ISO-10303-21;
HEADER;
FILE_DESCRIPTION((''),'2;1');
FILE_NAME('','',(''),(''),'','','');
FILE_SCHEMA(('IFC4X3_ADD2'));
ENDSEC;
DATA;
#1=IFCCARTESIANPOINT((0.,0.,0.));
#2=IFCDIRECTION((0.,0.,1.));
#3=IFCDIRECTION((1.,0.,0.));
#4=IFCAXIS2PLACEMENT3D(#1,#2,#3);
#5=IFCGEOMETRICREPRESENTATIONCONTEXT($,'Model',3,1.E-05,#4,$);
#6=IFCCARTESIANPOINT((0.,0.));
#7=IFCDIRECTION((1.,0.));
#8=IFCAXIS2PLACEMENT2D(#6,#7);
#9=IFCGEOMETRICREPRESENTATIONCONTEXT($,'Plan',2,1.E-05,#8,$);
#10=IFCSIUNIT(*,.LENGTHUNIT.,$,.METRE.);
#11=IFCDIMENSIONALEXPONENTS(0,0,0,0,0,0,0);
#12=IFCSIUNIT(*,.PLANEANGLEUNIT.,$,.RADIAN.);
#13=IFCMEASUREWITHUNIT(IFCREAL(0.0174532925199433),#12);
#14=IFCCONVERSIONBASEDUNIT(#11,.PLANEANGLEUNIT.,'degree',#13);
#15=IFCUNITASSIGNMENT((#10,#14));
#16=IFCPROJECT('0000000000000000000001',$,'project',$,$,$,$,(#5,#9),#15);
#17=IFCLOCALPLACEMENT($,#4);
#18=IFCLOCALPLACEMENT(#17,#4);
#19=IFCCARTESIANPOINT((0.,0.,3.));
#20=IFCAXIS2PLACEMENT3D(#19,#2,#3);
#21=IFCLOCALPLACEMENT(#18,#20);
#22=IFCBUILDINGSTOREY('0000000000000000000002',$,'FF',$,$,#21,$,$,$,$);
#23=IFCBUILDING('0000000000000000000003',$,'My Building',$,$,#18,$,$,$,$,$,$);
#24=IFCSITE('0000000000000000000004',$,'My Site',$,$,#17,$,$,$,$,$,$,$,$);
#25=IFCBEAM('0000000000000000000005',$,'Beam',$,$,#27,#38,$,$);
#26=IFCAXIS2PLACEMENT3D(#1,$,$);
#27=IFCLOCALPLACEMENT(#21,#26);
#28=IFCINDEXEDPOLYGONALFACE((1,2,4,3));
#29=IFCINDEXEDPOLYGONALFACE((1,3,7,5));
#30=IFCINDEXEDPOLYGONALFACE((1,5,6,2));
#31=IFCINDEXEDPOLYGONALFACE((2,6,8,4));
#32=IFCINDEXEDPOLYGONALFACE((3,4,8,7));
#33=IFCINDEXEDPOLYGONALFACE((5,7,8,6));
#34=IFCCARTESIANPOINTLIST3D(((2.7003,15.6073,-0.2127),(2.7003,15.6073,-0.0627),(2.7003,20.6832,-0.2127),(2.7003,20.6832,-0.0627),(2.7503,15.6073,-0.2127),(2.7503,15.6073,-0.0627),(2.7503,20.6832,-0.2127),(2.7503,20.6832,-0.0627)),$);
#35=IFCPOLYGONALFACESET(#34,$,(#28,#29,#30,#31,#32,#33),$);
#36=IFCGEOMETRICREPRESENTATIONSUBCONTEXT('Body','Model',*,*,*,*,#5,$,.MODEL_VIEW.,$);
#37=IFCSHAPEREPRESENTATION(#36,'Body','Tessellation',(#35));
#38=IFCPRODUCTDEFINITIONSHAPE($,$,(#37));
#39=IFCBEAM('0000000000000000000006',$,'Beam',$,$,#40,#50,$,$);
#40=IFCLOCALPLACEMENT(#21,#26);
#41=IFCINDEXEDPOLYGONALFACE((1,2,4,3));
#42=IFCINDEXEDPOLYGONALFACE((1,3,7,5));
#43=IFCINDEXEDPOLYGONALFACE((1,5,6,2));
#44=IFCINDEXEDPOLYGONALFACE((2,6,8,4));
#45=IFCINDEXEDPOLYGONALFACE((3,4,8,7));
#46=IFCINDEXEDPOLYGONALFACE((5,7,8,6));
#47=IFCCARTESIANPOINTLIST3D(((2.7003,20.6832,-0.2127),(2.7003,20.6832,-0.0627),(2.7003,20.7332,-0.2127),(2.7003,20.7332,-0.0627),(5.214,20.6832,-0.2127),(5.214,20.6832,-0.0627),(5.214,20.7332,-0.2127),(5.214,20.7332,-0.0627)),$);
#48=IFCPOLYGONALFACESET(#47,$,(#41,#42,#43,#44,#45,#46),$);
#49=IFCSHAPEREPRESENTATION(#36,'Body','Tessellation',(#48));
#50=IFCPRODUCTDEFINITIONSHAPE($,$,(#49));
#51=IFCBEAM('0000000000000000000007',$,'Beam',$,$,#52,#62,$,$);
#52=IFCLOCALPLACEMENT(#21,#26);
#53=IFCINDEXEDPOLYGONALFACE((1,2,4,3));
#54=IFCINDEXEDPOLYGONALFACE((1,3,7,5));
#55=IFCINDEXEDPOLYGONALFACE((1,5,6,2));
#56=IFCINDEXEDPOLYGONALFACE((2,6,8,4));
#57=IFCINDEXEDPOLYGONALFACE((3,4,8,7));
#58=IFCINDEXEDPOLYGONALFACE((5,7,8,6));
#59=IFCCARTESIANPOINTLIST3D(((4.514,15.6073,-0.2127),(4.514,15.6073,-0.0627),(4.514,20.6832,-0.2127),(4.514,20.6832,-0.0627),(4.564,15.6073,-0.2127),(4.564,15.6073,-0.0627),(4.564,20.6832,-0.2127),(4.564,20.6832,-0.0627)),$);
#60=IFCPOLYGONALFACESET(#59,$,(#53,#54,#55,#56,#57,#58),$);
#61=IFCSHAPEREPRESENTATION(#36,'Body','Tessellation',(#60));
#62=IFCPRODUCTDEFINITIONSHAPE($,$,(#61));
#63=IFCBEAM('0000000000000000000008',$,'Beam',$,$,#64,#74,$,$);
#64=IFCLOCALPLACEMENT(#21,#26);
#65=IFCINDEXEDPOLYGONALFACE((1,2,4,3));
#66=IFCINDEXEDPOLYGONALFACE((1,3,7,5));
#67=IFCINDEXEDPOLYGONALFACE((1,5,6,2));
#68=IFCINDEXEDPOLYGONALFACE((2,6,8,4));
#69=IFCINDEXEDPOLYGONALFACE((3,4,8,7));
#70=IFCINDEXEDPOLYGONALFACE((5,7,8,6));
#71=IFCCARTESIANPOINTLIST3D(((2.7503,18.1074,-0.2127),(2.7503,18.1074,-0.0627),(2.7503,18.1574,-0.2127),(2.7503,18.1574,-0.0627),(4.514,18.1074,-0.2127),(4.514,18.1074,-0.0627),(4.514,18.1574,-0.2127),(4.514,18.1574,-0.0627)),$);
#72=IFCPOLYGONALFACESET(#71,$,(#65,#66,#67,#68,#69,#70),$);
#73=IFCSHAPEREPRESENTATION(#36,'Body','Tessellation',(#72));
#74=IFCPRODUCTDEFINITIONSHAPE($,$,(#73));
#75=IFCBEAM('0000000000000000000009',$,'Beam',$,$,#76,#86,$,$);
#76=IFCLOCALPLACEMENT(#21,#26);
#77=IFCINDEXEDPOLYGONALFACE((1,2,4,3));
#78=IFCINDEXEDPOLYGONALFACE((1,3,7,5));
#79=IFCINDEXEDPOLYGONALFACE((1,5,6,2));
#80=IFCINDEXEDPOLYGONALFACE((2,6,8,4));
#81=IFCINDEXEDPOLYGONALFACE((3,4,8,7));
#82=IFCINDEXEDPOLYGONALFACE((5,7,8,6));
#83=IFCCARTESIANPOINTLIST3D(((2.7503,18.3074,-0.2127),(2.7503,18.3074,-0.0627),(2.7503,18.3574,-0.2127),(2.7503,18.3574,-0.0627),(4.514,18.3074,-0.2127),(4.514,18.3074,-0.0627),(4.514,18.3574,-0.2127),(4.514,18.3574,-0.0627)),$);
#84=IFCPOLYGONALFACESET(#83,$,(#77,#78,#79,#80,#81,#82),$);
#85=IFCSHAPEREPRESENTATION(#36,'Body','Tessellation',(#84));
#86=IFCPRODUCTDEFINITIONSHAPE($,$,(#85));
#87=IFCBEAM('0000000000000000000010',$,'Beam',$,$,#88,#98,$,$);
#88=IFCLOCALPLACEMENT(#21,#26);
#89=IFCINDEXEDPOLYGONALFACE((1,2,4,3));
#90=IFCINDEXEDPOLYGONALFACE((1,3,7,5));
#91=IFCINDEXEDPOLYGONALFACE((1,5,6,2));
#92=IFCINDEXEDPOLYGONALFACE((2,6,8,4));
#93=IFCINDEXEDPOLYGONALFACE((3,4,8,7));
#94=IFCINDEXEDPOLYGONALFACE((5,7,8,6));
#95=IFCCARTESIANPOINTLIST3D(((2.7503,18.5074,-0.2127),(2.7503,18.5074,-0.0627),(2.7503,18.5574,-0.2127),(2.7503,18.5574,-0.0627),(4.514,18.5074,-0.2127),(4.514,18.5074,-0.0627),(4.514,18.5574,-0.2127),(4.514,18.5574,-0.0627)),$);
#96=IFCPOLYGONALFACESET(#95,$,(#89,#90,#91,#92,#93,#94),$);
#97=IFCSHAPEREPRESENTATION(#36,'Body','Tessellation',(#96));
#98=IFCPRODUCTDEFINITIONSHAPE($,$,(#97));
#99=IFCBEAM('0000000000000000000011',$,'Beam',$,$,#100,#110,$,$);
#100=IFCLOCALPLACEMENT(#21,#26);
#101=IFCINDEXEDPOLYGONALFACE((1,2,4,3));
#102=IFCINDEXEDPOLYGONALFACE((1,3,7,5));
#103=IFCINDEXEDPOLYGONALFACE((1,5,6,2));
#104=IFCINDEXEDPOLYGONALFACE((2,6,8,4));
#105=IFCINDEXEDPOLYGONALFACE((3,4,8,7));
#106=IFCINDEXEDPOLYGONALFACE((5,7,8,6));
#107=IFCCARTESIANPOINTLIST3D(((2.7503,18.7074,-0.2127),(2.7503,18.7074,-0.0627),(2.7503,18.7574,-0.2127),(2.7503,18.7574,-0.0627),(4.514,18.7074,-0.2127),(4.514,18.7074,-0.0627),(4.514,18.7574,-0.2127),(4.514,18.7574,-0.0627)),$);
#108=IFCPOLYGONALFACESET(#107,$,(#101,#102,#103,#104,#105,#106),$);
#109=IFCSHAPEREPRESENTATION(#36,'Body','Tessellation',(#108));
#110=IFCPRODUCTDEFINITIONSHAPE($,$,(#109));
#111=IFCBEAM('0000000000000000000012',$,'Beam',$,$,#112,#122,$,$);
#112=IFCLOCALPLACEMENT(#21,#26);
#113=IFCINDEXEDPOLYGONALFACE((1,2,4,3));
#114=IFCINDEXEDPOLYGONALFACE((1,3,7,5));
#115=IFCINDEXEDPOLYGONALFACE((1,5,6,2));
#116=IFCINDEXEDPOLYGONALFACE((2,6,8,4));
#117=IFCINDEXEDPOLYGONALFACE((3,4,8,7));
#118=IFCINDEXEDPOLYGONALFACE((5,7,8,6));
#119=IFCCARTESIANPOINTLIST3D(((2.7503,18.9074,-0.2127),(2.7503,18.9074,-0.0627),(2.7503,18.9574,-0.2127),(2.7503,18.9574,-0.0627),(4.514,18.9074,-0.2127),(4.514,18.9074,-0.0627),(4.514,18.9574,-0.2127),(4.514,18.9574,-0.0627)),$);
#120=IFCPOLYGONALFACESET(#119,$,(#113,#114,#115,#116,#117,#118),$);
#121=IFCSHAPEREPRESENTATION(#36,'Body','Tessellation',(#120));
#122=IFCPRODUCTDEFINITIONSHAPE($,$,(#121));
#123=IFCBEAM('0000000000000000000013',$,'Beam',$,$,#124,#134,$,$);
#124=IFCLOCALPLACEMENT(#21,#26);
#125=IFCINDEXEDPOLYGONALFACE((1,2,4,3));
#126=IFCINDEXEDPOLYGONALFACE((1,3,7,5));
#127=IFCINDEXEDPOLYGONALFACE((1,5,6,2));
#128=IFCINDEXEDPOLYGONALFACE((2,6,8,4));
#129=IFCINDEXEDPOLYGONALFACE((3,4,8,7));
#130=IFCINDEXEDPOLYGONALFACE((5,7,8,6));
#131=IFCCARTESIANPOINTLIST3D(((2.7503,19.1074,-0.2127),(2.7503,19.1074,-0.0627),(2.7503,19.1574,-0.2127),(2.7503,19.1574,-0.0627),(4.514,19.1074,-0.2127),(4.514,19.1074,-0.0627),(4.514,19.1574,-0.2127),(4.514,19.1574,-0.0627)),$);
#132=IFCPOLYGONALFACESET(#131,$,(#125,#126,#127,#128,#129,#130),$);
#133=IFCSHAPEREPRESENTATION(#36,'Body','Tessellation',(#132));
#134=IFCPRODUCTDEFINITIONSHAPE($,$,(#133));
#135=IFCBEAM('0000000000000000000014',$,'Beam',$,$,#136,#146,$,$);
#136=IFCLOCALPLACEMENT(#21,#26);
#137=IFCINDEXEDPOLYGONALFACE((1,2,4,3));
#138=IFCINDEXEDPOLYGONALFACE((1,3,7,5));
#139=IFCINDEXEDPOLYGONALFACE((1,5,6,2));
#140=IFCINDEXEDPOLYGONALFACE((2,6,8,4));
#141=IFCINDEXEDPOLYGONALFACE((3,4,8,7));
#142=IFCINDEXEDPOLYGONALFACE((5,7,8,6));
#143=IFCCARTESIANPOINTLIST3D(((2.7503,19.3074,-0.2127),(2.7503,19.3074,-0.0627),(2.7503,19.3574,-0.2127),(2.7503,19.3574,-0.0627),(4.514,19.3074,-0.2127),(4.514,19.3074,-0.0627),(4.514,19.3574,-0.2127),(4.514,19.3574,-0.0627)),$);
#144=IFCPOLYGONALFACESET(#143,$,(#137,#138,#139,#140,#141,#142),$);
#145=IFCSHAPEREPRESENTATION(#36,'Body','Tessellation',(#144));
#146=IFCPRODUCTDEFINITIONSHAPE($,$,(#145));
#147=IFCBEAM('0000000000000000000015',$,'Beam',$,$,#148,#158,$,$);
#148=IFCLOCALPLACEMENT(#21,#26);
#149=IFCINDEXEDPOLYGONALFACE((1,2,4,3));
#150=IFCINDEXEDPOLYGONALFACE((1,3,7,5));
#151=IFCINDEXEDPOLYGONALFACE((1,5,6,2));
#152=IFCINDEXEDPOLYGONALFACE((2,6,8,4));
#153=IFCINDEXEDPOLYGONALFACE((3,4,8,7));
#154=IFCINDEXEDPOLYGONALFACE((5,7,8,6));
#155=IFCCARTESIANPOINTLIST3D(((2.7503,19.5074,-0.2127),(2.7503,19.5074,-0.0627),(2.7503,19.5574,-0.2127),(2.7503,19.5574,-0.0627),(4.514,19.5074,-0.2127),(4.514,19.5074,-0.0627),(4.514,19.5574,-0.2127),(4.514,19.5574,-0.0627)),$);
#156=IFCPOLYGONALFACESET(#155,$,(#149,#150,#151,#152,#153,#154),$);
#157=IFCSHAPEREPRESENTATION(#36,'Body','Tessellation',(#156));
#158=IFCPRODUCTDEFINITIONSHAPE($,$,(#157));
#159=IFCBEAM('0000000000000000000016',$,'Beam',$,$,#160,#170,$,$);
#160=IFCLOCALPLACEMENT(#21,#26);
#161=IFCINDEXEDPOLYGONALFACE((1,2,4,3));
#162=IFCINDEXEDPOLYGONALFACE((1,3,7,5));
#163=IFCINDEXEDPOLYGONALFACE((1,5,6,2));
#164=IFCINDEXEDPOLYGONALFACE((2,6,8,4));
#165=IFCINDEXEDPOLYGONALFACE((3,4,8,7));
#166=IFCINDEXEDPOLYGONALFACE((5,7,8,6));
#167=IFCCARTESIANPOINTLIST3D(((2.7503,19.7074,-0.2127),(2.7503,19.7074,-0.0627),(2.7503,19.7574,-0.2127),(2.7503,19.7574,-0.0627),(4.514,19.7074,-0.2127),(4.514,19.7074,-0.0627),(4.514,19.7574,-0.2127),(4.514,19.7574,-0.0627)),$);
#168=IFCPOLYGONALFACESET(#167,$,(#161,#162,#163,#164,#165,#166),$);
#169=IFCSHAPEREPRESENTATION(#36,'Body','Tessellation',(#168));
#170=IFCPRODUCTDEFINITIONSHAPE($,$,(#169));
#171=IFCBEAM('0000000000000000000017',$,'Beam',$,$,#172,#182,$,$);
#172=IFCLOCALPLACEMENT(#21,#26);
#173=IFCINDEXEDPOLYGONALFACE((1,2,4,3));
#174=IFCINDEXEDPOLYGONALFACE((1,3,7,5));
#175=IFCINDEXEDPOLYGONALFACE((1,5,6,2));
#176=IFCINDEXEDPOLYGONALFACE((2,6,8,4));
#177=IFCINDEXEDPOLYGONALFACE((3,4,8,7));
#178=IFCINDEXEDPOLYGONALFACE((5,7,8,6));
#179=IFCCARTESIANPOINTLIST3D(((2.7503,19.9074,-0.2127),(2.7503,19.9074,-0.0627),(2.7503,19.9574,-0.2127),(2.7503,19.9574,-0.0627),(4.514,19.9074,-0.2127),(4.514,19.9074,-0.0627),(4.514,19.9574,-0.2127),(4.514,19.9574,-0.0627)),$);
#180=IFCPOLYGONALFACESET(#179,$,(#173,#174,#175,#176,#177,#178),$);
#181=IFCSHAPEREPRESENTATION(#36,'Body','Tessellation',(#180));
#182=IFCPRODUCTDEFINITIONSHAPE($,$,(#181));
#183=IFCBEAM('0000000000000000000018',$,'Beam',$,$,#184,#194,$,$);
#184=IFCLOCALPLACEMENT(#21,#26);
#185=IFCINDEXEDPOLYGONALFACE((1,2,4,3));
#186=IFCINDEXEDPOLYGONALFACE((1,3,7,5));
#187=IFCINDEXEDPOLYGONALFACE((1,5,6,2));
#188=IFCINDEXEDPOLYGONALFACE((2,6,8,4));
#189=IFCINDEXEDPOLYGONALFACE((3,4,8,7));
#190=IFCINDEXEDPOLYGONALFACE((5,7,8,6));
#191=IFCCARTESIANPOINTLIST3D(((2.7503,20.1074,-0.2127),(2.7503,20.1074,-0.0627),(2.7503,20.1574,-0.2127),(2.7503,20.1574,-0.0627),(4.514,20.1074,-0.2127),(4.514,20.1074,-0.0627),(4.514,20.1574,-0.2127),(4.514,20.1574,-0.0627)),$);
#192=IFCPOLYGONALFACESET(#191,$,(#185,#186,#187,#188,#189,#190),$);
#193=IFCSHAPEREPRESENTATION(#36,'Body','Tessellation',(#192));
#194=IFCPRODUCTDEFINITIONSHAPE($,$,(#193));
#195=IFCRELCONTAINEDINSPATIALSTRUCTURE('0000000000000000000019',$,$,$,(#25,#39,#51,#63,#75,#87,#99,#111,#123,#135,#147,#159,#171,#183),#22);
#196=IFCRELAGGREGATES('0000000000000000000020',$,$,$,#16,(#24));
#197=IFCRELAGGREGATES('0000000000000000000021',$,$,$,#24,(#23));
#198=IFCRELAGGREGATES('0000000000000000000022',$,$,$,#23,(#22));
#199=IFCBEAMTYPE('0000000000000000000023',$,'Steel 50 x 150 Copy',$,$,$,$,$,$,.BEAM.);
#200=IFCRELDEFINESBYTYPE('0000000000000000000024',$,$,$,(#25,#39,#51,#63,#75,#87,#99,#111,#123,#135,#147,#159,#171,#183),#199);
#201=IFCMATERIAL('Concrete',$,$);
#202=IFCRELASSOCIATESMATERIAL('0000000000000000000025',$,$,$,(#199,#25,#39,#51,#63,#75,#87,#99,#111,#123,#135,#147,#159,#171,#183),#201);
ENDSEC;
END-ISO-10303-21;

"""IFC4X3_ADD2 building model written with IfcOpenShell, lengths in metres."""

from ifc_helpers import new_model, entity, si_unit, converted_unit, frame, origin_with_axes, origin_2d_with_axis, place, context, subcontext, project, spatial, rectangle, extrude, material, material_profile, profile_set, profile_usage, type_object, element, save


model = new_model("IFC4X3_ADD2")

# Units and contexts
model_context = context("Model", 3, precision=1e-05, world=origin_with_axes())
plan_context = context("Plan", 2, precision=1e-05, world=origin_2d_with_axis())
body_context = subcontext(model_context, "Body", "Model", "MODEL_VIEW")
ifc_project = project(units=[si_unit("LENGTHUNIT", "METRE"), converted_unit("PLANEANGLEUNIT", "degree", entity("IfcReal", 0.0174532925199433), si_unit("PLANEANGLEUNIT", "RADIAN"), dimensions=[0, 0, 0, 0, 0, 0, 0])], contexts=[model_context, plan_context])

# Site, building, storey
site_placement = place(None, origin_with_axes())
site = spatial("IfcSite", under=ifc_project, at=site_placement, Name="My Site")
building_placement = place(site_placement, origin_with_axes())
building = spatial("IfcBuilding", under=site, at=building_placement, Name="My Building")
storey_placement = place(building_placement, frame((0.0, 0.0, 3.0), z_axis=(0.0, 0.0, 1.0), x_axis=(1.0, 0.0, 0.0)))
storey = spatial("IfcBuildingStorey", under=building, at=storey_placement, Name="FF")

# Beams
ifc_material = material(Name="Concrete")
ifc_material_profile = material_profile(ifc_material, rectangle(XDim=0.05, YDim=0.15))
ifc_profile_set = profile_set([ifc_material_profile])
ifc_profile_usage_1 = profile_usage(ifc_profile_set)
beam_type = type_object("IfcBeamType", Name="Steel 50 x 150 Copy", PredefinedType="BEAM", material=ifc_profile_set)
beam_1_placement = place(storey_placement, frame((2.7253, 20.6832, -0.1377), z_axis=(0.0, -1.0, 0.0), x_axis=(1.0, 0.0, 0.0)))
element("IfcBeam", 1, at=beam_1_placement, inside=storey, type_object=beam_type, material=ifc_profile_usage_1, Name="Beam", context=body_context, shape_type="SweptSolid", body=[
    extrude(rectangle(XDim=0.05, YDim=0.15), origin_with_axes(), (0.0, 0.0, 1.0), 5.0758),
])
ifc_profile_usage_2 = profile_usage(ifc_profile_set)
beam_2_placement = place(storey_placement, frame((2.7003, 20.7082, -0.1377), z_axis=(1.0, 0.0, 0.0), x_axis=(0.0, 1.0, 0.0)))
element("IfcBeam", 2, at=beam_2_placement, inside=storey, type_object=beam_type, material=ifc_profile_usage_2, Name="Beam", context=body_context, shape_type="SweptSolid", body=[
    extrude(rectangle(XDim=0.05, YDim=0.15), origin_with_axes(), (0.0, 0.0, 1.0), 2.5138),
])
ifc_profile_usage_3 = profile_usage(ifc_profile_set)
beam_3_placement = place(storey_placement, frame((4.539, 20.6832, -0.1377), z_axis=(0.0, -1.0, 0.0), x_axis=(1.0, 0.0, 0.0)))
element("IfcBeam", 3, at=beam_3_placement, inside=storey, type_object=beam_type, material=ifc_profile_usage_3, Name="Beam", context=body_context, shape_type="SweptSolid", body=[
    extrude(rectangle(XDim=0.05, YDim=0.15), origin_with_axes(), (0.0, 0.0, 1.0), 5.0758),
])
ifc_profile_usage_4 = profile_usage(ifc_profile_set)
beam_4_placement = place(storey_placement, frame((2.7503, 18.1324, -0.1377), z_axis=(1.0, 0.0, 0.0), x_axis=(0.0, 1.0, 0.0)))
element("IfcBeam", 4, at=beam_4_placement, inside=storey, type_object=beam_type, material=ifc_profile_usage_4, Name="Beam", context=body_context, shape_type="SweptSolid", body=[
    extrude(rectangle(XDim=0.05, YDim=0.15), origin_with_axes(), (0.0, 0.0, 1.0), 1.7638),
])
ifc_profile_usage_5 = profile_usage(ifc_profile_set)
beam_5_placement = place(storey_placement, frame((2.7503, 18.3324, -0.1377), z_axis=(1.0, 0.0, 0.0), x_axis=(0.0, 1.0, 0.0)))
element("IfcBeam", 5, at=beam_5_placement, inside=storey, type_object=beam_type, material=ifc_profile_usage_5, Name="Beam", context=body_context, shape_type="SweptSolid", body=[
    extrude(rectangle(XDim=0.05, YDim=0.15), origin_with_axes(), (0.0, 0.0, 1.0), 1.7638),
])
ifc_profile_usage_6 = profile_usage(ifc_profile_set)
beam_6_placement = place(storey_placement, frame((2.7503, 18.5324, -0.1377), z_axis=(1.0, 0.0, 0.0), x_axis=(0.0, 1.0, 0.0)))
element("IfcBeam", 6, at=beam_6_placement, inside=storey, type_object=beam_type, material=ifc_profile_usage_6, Name="Beam", context=body_context, shape_type="SweptSolid", body=[
    extrude(rectangle(XDim=0.05, YDim=0.15), origin_with_axes(), (0.0, 0.0, 1.0), 1.7638),
])
ifc_profile_usage_7 = profile_usage(ifc_profile_set)
beam_7_placement = place(storey_placement, frame((2.7503, 18.7324, -0.1377), z_axis=(1.0, 0.0, 0.0), x_axis=(0.0, 1.0, 0.0)))
element("IfcBeam", 7, at=beam_7_placement, inside=storey, type_object=beam_type, material=ifc_profile_usage_7, Name="Beam", context=body_context, shape_type="SweptSolid", body=[
    extrude(rectangle(XDim=0.05, YDim=0.15), origin_with_axes(), (0.0, 0.0, 1.0), 1.7638),
])
ifc_profile_usage_8 = profile_usage(ifc_profile_set)
beam_8_placement = place(storey_placement, frame((2.7503, 18.9324, -0.1377), z_axis=(1.0, 0.0, 0.0), x_axis=(0.0, 1.0, 0.0)))
element("IfcBeam", 8, at=beam_8_placement, inside=storey, type_object=beam_type, material=ifc_profile_usage_8, Name="Beam", context=body_context, shape_type="SweptSolid", body=[
    extrude(rectangle(XDim=0.05, YDim=0.15), origin_with_axes(), (0.0, 0.0, 1.0), 1.7638),
])
ifc_profile_usage_9 = profile_usage(ifc_profile_set)
beam_9_placement = place(storey_placement, frame((2.7503, 19.1324, -0.1377), z_axis=(1.0, 0.0, 0.0), x_axis=(0.0, 1.0, 0.0)))
element("IfcBeam", 9, at=beam_9_placement, inside=storey, type_object=beam_type, material=ifc_profile_usage_9, Name="Beam", context=body_context, shape_type="SweptSolid", body=[
    extrude(rectangle(XDim=0.05, YDim=0.15), origin_with_axes(), (0.0, 0.0, 1.0), 1.7638),
])
ifc_profile_usage_10 = profile_usage(ifc_profile_set)
beam_10_placement = place(storey_placement, frame((2.7503, 19.3324, -0.1377), z_axis=(1.0, 0.0, 0.0), x_axis=(0.0, 1.0, 0.0)))
element("IfcBeam", 10, at=beam_10_placement, inside=storey, type_object=beam_type, material=ifc_profile_usage_10, Name="Beam", context=body_context, shape_type="SweptSolid", body=[
    extrude(rectangle(XDim=0.05, YDim=0.15), origin_with_axes(), (0.0, 0.0, 1.0), 1.7638),
])
ifc_profile_usage_11 = profile_usage(ifc_profile_set)
beam_11_placement = place(storey_placement, frame((2.7503, 19.5324, -0.1377), z_axis=(1.0, 0.0, 0.0), x_axis=(0.0, 1.0, 0.0)))
element("IfcBeam", 11, at=beam_11_placement, inside=storey, type_object=beam_type, material=ifc_profile_usage_11, Name="Beam", context=body_context, shape_type="SweptSolid", body=[
    extrude(rectangle(XDim=0.05, YDim=0.15), origin_with_axes(), (0.0, 0.0, 1.0), 1.7638),
])
ifc_profile_usage_12 = profile_usage(ifc_profile_set)
beam_12_placement = place(storey_placement, frame((2.7503, 19.7324, -0.1377), z_axis=(1.0, 0.0, 0.0), x_axis=(0.0, 1.0, 0.0)))
element("IfcBeam", 12, at=beam_12_placement, inside=storey, type_object=beam_type, material=ifc_profile_usage_12, Name="Beam", context=body_context, shape_type="SweptSolid", body=[
    extrude(rectangle(XDim=0.05, YDim=0.15), origin_with_axes(), (0.0, 0.0, 1.0), 1.7638),
])
ifc_profile_usage_13 = profile_usage(ifc_profile_set)
beam_13_placement = place(storey_placement, frame((2.7503, 19.9324, -0.1377), z_axis=(1.0, 0.0, 0.0), x_axis=(0.0, 1.0, 0.0)))
element("IfcBeam", 13, at=beam_13_placement, inside=storey, type_object=beam_type, material=ifc_profile_usage_13, Name="Beam", context=body_context, shape_type="SweptSolid", body=[
    extrude(rectangle(XDim=0.05, YDim=0.15), origin_with_axes(), (0.0, 0.0, 1.0), 1.7638),
])
ifc_profile_usage_14 = profile_usage(ifc_profile_set)
beam_14_placement = place(storey_placement, frame((2.7503, 20.1324, -0.1377), z_axis=(1.0, 0.0, 0.0), x_axis=(0.0, 1.0, 0.0)))
element("IfcBeam", 14, at=beam_14_placement, inside=storey, type_object=beam_type, material=ifc_profile_usage_14, Name="Beam", context=body_context, shape_type="SweptSolid", body=[
    extrude(rectangle(XDim=0.05, YDim=0.15), origin_with_axes(), (0.0, 0.0, 1.0), 1.7638),
])

save(model, "model.ifc")
